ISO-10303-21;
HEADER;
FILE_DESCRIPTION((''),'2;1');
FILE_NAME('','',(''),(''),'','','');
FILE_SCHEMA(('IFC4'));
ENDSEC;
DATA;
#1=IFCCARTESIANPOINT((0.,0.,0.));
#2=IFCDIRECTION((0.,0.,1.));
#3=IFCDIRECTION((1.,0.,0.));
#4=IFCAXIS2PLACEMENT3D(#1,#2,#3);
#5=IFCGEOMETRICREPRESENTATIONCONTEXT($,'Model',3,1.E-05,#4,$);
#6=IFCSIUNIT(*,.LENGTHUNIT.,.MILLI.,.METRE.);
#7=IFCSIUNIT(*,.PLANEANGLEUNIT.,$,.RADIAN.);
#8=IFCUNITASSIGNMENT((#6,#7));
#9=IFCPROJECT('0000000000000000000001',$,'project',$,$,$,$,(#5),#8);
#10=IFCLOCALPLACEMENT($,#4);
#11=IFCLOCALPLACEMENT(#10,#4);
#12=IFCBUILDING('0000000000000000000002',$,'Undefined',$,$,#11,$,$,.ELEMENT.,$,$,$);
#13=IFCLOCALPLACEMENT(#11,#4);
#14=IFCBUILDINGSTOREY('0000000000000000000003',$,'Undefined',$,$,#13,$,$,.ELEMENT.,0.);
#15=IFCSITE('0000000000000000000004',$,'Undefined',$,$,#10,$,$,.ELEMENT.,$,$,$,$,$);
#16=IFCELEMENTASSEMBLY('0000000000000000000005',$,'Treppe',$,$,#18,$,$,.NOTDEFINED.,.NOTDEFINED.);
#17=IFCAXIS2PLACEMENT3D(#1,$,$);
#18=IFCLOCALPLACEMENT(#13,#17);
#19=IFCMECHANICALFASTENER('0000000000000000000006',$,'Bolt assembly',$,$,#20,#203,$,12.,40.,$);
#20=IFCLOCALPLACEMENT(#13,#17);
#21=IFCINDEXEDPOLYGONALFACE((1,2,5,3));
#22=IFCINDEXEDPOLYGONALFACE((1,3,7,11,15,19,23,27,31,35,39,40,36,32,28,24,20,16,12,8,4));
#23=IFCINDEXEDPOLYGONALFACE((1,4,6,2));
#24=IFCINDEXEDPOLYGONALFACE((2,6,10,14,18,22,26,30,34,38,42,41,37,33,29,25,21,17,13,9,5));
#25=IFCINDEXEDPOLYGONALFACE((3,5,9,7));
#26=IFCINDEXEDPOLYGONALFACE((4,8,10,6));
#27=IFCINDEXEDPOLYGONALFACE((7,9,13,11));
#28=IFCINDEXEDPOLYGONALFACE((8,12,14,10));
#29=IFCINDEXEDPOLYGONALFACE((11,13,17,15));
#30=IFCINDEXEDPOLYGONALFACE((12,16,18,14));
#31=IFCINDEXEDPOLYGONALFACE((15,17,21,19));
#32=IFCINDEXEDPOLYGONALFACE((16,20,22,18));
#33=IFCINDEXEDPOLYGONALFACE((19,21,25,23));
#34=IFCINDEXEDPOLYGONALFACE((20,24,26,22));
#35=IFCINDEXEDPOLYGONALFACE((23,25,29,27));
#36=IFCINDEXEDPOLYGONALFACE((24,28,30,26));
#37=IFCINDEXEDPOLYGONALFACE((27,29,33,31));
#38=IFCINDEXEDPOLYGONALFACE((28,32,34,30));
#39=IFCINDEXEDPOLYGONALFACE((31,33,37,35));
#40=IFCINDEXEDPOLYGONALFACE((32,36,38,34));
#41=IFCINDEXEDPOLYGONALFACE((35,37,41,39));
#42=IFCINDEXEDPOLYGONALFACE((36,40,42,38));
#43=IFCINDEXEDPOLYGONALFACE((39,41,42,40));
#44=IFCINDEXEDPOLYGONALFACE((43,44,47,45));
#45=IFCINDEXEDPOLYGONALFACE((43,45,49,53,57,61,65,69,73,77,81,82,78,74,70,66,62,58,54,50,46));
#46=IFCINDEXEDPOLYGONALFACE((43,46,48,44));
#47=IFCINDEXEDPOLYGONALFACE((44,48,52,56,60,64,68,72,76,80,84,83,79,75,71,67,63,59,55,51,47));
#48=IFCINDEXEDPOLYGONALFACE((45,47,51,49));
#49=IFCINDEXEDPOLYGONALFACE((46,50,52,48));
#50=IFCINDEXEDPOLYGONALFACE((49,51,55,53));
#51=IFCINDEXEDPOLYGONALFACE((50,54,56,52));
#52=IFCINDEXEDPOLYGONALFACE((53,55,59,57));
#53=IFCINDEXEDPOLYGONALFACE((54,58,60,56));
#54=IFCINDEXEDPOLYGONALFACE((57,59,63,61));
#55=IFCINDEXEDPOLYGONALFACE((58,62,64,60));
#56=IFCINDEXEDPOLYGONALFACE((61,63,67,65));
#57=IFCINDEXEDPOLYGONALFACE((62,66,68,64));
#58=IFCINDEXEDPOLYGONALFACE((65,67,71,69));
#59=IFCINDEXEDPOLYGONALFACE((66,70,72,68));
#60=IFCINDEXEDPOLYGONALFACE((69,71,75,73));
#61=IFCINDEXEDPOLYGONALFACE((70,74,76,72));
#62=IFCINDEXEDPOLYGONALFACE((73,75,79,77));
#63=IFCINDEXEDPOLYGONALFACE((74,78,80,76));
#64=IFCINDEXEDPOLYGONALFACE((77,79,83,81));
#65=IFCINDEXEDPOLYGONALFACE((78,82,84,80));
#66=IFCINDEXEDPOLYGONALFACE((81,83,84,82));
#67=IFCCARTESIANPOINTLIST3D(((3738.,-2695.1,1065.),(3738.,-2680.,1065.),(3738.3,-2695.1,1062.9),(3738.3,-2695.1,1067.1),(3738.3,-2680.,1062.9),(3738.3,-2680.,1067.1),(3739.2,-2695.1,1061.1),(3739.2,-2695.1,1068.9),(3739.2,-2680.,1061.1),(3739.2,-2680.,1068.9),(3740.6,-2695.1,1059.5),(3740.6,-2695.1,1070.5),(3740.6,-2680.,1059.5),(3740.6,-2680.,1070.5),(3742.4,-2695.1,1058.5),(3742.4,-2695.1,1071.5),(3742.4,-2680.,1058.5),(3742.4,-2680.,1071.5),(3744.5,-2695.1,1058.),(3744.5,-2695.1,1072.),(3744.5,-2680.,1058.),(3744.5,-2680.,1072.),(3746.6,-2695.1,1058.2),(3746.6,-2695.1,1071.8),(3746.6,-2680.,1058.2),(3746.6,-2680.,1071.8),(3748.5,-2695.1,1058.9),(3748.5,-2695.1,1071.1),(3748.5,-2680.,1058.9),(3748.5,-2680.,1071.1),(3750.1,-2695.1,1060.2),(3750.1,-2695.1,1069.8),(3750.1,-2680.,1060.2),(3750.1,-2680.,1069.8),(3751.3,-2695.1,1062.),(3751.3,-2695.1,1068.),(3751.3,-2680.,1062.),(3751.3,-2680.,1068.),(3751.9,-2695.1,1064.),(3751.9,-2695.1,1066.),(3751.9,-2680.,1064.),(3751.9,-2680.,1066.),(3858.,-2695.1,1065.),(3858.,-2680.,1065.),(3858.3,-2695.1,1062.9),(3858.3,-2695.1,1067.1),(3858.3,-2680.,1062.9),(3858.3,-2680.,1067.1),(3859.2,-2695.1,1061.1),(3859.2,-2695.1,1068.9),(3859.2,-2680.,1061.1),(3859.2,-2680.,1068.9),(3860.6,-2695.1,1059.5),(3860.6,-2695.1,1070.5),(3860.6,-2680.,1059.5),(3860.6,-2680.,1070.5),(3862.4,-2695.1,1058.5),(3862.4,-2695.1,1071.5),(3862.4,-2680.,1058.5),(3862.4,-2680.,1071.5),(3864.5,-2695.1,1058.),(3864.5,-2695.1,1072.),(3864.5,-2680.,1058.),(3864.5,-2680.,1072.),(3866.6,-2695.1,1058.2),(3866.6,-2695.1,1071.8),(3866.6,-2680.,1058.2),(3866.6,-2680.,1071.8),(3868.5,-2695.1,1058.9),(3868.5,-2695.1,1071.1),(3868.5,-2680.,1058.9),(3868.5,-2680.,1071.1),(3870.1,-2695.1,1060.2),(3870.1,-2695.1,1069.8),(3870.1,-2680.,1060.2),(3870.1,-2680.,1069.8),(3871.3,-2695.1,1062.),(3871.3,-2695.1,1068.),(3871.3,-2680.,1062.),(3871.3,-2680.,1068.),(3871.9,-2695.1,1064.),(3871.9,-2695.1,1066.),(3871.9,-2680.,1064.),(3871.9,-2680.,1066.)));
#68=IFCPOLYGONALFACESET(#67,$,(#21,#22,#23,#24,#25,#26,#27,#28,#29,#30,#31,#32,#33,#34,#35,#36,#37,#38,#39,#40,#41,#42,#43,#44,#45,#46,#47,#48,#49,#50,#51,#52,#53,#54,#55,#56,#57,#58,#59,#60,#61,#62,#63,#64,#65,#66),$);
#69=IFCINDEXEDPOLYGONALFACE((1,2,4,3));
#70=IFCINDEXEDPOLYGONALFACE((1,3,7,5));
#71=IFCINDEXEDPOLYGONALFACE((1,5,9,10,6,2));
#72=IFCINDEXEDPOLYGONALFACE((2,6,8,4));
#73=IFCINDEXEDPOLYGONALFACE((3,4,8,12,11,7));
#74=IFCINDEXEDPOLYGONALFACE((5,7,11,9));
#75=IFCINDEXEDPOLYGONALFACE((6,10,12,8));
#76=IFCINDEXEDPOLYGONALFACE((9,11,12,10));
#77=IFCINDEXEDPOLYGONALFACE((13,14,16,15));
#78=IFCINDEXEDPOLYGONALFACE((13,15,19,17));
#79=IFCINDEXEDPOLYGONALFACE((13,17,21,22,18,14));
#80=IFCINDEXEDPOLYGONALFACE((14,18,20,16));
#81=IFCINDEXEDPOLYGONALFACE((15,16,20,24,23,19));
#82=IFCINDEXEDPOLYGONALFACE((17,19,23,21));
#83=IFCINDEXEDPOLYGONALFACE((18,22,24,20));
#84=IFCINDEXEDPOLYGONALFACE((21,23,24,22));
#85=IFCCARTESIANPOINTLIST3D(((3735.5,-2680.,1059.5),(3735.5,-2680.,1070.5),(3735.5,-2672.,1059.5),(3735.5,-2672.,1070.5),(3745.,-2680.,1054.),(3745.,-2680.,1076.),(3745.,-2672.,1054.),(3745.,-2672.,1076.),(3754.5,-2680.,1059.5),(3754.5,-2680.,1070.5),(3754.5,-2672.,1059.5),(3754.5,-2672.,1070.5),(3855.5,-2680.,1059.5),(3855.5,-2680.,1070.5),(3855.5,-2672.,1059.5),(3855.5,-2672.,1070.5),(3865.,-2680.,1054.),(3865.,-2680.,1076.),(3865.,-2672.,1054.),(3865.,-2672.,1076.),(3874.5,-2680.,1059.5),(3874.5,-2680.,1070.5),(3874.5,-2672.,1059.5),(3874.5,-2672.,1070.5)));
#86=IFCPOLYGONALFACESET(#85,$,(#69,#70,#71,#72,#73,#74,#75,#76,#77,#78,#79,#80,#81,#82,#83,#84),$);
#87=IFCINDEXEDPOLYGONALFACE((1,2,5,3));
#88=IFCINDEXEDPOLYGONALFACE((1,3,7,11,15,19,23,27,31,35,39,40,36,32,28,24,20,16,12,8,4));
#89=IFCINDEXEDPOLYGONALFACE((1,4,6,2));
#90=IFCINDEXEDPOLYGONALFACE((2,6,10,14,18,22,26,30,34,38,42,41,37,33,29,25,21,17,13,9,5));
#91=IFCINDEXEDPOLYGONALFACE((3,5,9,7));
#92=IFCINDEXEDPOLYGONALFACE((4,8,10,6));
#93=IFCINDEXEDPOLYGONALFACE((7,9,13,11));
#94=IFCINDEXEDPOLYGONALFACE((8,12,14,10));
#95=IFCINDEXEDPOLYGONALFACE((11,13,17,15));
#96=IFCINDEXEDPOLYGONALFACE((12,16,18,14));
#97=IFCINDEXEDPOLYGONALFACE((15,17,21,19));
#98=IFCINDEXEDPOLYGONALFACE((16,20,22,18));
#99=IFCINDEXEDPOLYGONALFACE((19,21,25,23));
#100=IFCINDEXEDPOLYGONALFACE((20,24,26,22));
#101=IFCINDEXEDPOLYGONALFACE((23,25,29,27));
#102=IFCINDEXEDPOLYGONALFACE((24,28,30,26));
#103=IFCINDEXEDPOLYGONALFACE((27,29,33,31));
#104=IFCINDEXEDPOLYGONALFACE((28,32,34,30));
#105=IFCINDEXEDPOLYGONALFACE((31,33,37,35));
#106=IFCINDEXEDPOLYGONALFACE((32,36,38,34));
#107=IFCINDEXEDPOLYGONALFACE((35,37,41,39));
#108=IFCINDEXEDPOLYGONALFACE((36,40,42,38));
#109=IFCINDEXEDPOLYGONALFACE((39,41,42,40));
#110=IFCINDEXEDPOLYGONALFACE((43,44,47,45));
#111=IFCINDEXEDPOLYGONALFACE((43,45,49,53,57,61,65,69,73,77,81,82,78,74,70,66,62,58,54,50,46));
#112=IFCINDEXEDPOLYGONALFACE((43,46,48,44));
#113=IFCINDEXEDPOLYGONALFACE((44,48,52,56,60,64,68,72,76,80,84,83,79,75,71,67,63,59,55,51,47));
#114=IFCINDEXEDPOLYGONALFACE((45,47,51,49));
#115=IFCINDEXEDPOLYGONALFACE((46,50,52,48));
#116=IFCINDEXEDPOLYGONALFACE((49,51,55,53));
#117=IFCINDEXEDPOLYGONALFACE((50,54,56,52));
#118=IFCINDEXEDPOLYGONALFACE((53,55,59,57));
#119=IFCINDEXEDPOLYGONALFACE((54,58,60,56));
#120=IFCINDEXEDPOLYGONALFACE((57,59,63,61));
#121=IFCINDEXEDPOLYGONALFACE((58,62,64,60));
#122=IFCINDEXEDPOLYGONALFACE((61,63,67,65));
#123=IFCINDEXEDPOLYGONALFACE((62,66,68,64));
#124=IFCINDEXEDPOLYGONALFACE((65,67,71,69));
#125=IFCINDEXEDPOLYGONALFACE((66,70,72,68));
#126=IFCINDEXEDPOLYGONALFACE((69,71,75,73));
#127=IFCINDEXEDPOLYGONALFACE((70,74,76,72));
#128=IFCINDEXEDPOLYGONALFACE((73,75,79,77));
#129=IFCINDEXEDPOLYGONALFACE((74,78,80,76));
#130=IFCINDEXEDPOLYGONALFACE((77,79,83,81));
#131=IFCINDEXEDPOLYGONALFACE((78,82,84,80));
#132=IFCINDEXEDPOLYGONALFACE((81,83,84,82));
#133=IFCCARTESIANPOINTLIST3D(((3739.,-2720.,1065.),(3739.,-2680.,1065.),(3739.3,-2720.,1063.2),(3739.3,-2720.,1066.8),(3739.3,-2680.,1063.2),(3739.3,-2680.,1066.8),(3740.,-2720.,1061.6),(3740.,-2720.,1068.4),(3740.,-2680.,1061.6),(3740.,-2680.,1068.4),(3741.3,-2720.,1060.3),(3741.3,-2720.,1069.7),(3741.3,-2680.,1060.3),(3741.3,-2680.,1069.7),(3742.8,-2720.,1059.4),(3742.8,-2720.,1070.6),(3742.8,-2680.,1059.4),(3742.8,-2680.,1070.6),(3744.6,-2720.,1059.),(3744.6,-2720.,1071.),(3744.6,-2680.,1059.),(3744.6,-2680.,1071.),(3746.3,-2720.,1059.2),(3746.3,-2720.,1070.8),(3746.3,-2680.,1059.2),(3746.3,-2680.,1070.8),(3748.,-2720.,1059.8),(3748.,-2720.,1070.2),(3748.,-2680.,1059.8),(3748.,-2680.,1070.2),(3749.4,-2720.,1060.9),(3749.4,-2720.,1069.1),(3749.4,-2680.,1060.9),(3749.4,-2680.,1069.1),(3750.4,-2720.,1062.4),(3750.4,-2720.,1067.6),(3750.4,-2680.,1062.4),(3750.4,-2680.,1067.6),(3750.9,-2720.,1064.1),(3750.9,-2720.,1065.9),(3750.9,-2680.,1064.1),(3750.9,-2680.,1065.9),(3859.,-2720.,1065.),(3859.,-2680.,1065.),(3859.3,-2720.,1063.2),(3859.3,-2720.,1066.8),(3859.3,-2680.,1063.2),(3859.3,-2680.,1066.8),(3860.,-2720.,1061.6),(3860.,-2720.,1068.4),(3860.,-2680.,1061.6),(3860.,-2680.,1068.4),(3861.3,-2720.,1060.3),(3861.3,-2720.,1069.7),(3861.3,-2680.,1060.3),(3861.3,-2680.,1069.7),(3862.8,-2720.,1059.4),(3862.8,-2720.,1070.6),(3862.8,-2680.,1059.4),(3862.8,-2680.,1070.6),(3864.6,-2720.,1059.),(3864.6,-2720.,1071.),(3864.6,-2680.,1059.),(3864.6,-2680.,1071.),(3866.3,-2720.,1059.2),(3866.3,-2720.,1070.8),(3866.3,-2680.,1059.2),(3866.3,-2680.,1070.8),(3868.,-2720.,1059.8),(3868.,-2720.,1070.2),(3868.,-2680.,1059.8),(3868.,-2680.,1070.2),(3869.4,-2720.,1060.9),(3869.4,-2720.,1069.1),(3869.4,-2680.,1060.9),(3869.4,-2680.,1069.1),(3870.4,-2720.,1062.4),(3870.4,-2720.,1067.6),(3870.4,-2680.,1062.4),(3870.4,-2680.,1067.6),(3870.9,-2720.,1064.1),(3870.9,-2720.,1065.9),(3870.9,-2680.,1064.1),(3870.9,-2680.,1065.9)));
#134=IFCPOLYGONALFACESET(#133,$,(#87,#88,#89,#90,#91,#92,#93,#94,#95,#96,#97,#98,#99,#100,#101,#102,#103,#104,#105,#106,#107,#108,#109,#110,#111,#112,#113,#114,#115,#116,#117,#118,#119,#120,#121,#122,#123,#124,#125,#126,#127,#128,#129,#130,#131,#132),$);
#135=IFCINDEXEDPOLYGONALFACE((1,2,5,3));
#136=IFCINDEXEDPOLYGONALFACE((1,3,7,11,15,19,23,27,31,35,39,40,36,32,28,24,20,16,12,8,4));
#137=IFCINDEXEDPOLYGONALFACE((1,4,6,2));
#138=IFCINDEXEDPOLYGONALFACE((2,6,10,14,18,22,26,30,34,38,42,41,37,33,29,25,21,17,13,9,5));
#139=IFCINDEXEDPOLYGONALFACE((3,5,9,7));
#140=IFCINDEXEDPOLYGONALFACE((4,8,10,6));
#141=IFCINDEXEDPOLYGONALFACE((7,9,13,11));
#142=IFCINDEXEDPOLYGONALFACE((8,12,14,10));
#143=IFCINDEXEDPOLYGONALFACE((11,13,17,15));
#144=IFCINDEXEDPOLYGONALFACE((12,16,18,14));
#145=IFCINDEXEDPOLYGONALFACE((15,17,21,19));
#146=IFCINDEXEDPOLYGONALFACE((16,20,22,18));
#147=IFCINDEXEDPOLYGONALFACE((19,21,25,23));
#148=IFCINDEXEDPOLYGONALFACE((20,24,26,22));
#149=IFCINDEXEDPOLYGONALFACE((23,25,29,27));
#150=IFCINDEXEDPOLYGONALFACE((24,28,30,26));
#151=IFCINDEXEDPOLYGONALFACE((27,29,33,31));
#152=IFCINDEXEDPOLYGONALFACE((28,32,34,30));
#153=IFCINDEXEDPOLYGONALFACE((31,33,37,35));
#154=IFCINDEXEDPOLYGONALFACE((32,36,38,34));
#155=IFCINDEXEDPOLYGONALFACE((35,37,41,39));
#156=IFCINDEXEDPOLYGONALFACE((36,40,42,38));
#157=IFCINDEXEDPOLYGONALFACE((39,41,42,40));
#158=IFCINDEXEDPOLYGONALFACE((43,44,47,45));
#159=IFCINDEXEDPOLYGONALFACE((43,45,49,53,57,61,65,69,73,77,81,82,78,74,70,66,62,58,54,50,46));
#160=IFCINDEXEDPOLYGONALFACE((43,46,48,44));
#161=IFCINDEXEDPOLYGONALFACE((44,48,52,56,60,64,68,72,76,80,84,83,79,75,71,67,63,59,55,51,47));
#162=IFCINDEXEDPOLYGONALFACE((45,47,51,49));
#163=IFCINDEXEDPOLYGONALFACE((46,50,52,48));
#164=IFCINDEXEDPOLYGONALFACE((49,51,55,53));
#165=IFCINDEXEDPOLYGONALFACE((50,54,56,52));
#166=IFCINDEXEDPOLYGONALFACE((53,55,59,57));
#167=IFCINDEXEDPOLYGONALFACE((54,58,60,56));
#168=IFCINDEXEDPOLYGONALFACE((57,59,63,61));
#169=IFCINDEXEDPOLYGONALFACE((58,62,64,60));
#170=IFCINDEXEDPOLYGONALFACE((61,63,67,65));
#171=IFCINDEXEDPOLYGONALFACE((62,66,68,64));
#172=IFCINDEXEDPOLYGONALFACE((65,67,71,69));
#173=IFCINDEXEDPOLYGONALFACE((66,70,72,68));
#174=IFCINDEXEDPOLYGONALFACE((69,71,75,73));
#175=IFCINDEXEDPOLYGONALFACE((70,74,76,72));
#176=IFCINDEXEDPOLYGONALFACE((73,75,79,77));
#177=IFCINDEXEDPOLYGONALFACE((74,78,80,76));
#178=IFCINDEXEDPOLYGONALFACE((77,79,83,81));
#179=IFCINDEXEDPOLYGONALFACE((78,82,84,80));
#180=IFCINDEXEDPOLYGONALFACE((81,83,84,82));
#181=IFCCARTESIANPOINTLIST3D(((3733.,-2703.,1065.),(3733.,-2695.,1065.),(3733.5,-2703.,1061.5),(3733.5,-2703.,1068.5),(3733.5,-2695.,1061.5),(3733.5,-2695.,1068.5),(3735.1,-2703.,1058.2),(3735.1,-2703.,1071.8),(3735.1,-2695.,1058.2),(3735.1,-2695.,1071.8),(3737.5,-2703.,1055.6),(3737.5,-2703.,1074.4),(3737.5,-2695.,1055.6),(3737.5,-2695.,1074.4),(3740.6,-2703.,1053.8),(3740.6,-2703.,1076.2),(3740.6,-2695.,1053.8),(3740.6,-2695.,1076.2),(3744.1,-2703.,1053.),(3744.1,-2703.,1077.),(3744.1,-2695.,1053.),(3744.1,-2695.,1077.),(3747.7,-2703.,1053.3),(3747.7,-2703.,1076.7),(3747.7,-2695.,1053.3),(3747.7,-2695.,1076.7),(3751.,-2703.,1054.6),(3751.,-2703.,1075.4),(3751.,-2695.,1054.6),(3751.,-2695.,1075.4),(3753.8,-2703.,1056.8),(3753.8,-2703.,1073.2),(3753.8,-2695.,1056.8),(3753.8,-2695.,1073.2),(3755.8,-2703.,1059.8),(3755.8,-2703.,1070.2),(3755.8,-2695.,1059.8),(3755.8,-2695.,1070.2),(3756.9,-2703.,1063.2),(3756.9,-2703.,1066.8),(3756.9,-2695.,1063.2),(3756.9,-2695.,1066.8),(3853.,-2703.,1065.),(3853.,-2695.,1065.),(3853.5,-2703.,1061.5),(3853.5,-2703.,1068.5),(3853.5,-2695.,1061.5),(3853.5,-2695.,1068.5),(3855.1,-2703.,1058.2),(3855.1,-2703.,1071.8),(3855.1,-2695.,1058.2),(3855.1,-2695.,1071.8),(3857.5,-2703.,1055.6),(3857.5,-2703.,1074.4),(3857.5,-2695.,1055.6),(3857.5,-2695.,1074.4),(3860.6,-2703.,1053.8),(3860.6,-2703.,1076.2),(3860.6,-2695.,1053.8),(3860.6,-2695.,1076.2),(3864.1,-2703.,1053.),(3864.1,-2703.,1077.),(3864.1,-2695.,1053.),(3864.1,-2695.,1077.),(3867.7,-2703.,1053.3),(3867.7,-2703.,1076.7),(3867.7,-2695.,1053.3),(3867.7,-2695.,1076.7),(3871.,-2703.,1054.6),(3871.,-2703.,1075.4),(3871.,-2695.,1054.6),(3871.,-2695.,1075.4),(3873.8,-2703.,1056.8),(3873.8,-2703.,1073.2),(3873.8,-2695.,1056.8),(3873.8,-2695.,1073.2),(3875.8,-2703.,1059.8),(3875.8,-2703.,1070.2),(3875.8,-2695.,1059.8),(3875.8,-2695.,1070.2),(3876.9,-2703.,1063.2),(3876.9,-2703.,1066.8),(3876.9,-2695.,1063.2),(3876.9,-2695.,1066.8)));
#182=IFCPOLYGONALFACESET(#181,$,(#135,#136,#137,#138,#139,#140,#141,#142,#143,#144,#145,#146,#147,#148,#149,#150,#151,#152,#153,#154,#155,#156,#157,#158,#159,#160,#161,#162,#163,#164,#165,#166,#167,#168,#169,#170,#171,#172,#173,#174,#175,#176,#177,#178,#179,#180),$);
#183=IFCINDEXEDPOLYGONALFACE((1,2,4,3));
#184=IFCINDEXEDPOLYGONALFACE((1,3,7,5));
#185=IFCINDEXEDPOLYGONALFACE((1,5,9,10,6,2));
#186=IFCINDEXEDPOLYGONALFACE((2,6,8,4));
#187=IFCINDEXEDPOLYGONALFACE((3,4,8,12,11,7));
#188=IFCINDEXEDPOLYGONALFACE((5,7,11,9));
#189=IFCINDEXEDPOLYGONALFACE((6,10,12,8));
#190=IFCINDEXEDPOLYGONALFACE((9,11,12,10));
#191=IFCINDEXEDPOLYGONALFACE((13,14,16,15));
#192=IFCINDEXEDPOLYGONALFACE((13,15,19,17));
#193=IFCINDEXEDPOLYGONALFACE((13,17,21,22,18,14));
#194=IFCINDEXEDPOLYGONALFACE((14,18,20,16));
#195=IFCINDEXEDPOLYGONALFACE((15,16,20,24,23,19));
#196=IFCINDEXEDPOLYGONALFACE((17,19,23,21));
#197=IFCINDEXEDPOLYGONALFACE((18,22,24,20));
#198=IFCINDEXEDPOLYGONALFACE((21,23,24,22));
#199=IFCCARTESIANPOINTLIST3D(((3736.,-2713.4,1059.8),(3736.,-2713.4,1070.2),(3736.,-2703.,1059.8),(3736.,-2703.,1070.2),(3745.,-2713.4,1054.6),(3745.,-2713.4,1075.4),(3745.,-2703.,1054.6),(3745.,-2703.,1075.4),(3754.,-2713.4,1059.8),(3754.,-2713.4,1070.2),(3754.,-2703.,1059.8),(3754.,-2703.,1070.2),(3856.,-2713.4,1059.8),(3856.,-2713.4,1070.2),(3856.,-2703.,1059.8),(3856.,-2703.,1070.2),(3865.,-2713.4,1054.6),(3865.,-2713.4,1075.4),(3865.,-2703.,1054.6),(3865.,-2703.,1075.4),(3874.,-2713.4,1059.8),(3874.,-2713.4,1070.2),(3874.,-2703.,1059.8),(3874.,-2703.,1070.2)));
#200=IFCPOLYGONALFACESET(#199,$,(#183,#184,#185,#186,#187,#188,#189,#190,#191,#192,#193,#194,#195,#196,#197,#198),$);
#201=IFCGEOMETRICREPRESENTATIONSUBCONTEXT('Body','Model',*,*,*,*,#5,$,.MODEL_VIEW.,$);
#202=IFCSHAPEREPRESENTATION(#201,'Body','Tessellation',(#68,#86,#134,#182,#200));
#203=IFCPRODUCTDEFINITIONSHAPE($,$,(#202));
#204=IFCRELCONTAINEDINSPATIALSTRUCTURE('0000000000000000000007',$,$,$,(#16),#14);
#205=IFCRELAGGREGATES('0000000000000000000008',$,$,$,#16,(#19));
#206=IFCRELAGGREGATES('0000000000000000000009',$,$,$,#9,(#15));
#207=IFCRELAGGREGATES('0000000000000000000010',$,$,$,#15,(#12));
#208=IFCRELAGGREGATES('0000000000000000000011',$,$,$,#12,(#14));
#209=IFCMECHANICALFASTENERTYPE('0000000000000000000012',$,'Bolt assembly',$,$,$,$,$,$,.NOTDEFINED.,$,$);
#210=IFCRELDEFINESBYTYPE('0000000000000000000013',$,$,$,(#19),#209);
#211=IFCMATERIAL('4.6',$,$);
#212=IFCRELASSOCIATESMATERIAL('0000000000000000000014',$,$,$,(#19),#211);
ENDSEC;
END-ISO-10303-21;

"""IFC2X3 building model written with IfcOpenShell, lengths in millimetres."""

from ifc_helpers import new_model, si_unit, frame, origin_with_axes, origin_2d_with_axis, place, context, subcontext, project, spatial, polyline, circle, outline, extrude, source, transform, mapped, material, type_object, element, aggregate, save


model = new_model("IFC2X3")

# Units and contexts
model_context = context("Model", 3, precision=1e-05, world=origin_with_axes())
body_context = subcontext(model_context, "Body", "Model", "MODEL_VIEW")
ifc_project = project(units=[si_unit("LENGTHUNIT", "METRE", prefix="MILLI"), si_unit("PLANEANGLEUNIT", "RADIAN")], contexts=[model_context])

# Site, building, storey
site_placement = place(None, origin_with_axes())
site = spatial("IfcSite", under=ifc_project, at=site_placement, Name="Undefined", CompositionType="ELEMENT")
building_placement = place(site_placement, origin_with_axes())
building = spatial("IfcBuilding", under=site, at=building_placement, Name="Undefined", CompositionType="ELEMENT")
storey_placement = place(building_placement, origin_with_axes())
storey = spatial("IfcBuildingStorey", under=building, at=storey_placement, Name="Undefined", CompositionType="ELEMENT", Elevation=0.0)

# Element assembly, mechanical fastener
ifc_material_1 = material(Name="4.6")
mechanical_fastener_type = type_object("IfcMechanicalFastenerType", Name="Bolt assembly")
assembly_1_placement = place(storey_placement, origin_with_axes())
assembly_1 = element("IfcElementAssembly", 1, at=assembly_1_placement, inside=storey, Name="Treppe", AssemblyPlace="NOTDEFINED", PredefinedType="NOTDEFINED")
shared_shape_1 = source(origin_with_axes(), body_context, "Body", "SweptSolid", [
    extrude(circle(Radius=7.0, at=origin_2d_with_axis()), frame((0.0, -15.0, 0.0), z_axis=(0.0, 1.0, 0.0), x_axis=(1.0, 0.0, 0.0)), (0.0, 0.0, 1.0), 15.1),
    extrude(outline(polyline([(9.5, -5.5), (9.5, 5.5), (0.0, 11.0), (-9.5, 5.5), (-9.5, -5.5), (0.0, -11.0), (9.5, -5.5)])), frame((0.0, -23.0, 0.0), z_axis=(0.0, 1.0, 0.0), x_axis=(1.0, 0.0, 0.0)), (0.0, 0.0, 1.0), 8.0),
    extrude(circle(Radius=6.0, at=origin_2d_with_axis()), frame((0.0, -15.0, 0.0), z_axis=(0.0, 1.0, 0.0), x_axis=(1.0, 0.0, 0.0)), (0.0, 0.0, 1.0), 40.0),
    extrude(circle(Radius=12.0, at=origin_2d_with_axis()), frame((0.0, 0.0, 0.0), z_axis=(0.0, 1.0, 0.0), x_axis=(1.0, 0.0, 0.0)), (0.0, 0.0, 1.0), 8.0),
    extrude(outline(polyline([(9.0, -5.2), (9.0, 5.2), (0.0, 10.4), (-9.0, 5.2), (-9.0, -5.2), (0.0, -10.4), (9.0, -5.2)])), frame((0.0, 8.0, 0.0), z_axis=(0.0, 1.0, 0.0), x_axis=(1.0, 0.0, 0.0)), (0.0, 0.0, 1.0), 10.4),
])
mechanical_fastener_1_placement = place(assembly_1_placement, frame((3865.0, -2695.0, 1065.0), z_axis=(0.0, 0.0, 1.0), x_axis=(-1.0, 0.0, 0.0)))
mechanical_fastener_1 = element("IfcMechanicalFastener", 2, at=mechanical_fastener_1_placement, type_object=mechanical_fastener_type, material=ifc_material_1, Name="Bolt assembly", NominalDiameter=12.0, NominalLength=40.0, context=body_context, shape_type="MappedRepresentation", body=[
    mapped(shared_shape_1, transform((0.0, 0.0, 0.0))),
    mapped(shared_shape_1, transform((120.0, 0.0, 0.0))),
])
aggregate(assembly_1, [mechanical_fastener_1])

save(model, "model.ifc")
